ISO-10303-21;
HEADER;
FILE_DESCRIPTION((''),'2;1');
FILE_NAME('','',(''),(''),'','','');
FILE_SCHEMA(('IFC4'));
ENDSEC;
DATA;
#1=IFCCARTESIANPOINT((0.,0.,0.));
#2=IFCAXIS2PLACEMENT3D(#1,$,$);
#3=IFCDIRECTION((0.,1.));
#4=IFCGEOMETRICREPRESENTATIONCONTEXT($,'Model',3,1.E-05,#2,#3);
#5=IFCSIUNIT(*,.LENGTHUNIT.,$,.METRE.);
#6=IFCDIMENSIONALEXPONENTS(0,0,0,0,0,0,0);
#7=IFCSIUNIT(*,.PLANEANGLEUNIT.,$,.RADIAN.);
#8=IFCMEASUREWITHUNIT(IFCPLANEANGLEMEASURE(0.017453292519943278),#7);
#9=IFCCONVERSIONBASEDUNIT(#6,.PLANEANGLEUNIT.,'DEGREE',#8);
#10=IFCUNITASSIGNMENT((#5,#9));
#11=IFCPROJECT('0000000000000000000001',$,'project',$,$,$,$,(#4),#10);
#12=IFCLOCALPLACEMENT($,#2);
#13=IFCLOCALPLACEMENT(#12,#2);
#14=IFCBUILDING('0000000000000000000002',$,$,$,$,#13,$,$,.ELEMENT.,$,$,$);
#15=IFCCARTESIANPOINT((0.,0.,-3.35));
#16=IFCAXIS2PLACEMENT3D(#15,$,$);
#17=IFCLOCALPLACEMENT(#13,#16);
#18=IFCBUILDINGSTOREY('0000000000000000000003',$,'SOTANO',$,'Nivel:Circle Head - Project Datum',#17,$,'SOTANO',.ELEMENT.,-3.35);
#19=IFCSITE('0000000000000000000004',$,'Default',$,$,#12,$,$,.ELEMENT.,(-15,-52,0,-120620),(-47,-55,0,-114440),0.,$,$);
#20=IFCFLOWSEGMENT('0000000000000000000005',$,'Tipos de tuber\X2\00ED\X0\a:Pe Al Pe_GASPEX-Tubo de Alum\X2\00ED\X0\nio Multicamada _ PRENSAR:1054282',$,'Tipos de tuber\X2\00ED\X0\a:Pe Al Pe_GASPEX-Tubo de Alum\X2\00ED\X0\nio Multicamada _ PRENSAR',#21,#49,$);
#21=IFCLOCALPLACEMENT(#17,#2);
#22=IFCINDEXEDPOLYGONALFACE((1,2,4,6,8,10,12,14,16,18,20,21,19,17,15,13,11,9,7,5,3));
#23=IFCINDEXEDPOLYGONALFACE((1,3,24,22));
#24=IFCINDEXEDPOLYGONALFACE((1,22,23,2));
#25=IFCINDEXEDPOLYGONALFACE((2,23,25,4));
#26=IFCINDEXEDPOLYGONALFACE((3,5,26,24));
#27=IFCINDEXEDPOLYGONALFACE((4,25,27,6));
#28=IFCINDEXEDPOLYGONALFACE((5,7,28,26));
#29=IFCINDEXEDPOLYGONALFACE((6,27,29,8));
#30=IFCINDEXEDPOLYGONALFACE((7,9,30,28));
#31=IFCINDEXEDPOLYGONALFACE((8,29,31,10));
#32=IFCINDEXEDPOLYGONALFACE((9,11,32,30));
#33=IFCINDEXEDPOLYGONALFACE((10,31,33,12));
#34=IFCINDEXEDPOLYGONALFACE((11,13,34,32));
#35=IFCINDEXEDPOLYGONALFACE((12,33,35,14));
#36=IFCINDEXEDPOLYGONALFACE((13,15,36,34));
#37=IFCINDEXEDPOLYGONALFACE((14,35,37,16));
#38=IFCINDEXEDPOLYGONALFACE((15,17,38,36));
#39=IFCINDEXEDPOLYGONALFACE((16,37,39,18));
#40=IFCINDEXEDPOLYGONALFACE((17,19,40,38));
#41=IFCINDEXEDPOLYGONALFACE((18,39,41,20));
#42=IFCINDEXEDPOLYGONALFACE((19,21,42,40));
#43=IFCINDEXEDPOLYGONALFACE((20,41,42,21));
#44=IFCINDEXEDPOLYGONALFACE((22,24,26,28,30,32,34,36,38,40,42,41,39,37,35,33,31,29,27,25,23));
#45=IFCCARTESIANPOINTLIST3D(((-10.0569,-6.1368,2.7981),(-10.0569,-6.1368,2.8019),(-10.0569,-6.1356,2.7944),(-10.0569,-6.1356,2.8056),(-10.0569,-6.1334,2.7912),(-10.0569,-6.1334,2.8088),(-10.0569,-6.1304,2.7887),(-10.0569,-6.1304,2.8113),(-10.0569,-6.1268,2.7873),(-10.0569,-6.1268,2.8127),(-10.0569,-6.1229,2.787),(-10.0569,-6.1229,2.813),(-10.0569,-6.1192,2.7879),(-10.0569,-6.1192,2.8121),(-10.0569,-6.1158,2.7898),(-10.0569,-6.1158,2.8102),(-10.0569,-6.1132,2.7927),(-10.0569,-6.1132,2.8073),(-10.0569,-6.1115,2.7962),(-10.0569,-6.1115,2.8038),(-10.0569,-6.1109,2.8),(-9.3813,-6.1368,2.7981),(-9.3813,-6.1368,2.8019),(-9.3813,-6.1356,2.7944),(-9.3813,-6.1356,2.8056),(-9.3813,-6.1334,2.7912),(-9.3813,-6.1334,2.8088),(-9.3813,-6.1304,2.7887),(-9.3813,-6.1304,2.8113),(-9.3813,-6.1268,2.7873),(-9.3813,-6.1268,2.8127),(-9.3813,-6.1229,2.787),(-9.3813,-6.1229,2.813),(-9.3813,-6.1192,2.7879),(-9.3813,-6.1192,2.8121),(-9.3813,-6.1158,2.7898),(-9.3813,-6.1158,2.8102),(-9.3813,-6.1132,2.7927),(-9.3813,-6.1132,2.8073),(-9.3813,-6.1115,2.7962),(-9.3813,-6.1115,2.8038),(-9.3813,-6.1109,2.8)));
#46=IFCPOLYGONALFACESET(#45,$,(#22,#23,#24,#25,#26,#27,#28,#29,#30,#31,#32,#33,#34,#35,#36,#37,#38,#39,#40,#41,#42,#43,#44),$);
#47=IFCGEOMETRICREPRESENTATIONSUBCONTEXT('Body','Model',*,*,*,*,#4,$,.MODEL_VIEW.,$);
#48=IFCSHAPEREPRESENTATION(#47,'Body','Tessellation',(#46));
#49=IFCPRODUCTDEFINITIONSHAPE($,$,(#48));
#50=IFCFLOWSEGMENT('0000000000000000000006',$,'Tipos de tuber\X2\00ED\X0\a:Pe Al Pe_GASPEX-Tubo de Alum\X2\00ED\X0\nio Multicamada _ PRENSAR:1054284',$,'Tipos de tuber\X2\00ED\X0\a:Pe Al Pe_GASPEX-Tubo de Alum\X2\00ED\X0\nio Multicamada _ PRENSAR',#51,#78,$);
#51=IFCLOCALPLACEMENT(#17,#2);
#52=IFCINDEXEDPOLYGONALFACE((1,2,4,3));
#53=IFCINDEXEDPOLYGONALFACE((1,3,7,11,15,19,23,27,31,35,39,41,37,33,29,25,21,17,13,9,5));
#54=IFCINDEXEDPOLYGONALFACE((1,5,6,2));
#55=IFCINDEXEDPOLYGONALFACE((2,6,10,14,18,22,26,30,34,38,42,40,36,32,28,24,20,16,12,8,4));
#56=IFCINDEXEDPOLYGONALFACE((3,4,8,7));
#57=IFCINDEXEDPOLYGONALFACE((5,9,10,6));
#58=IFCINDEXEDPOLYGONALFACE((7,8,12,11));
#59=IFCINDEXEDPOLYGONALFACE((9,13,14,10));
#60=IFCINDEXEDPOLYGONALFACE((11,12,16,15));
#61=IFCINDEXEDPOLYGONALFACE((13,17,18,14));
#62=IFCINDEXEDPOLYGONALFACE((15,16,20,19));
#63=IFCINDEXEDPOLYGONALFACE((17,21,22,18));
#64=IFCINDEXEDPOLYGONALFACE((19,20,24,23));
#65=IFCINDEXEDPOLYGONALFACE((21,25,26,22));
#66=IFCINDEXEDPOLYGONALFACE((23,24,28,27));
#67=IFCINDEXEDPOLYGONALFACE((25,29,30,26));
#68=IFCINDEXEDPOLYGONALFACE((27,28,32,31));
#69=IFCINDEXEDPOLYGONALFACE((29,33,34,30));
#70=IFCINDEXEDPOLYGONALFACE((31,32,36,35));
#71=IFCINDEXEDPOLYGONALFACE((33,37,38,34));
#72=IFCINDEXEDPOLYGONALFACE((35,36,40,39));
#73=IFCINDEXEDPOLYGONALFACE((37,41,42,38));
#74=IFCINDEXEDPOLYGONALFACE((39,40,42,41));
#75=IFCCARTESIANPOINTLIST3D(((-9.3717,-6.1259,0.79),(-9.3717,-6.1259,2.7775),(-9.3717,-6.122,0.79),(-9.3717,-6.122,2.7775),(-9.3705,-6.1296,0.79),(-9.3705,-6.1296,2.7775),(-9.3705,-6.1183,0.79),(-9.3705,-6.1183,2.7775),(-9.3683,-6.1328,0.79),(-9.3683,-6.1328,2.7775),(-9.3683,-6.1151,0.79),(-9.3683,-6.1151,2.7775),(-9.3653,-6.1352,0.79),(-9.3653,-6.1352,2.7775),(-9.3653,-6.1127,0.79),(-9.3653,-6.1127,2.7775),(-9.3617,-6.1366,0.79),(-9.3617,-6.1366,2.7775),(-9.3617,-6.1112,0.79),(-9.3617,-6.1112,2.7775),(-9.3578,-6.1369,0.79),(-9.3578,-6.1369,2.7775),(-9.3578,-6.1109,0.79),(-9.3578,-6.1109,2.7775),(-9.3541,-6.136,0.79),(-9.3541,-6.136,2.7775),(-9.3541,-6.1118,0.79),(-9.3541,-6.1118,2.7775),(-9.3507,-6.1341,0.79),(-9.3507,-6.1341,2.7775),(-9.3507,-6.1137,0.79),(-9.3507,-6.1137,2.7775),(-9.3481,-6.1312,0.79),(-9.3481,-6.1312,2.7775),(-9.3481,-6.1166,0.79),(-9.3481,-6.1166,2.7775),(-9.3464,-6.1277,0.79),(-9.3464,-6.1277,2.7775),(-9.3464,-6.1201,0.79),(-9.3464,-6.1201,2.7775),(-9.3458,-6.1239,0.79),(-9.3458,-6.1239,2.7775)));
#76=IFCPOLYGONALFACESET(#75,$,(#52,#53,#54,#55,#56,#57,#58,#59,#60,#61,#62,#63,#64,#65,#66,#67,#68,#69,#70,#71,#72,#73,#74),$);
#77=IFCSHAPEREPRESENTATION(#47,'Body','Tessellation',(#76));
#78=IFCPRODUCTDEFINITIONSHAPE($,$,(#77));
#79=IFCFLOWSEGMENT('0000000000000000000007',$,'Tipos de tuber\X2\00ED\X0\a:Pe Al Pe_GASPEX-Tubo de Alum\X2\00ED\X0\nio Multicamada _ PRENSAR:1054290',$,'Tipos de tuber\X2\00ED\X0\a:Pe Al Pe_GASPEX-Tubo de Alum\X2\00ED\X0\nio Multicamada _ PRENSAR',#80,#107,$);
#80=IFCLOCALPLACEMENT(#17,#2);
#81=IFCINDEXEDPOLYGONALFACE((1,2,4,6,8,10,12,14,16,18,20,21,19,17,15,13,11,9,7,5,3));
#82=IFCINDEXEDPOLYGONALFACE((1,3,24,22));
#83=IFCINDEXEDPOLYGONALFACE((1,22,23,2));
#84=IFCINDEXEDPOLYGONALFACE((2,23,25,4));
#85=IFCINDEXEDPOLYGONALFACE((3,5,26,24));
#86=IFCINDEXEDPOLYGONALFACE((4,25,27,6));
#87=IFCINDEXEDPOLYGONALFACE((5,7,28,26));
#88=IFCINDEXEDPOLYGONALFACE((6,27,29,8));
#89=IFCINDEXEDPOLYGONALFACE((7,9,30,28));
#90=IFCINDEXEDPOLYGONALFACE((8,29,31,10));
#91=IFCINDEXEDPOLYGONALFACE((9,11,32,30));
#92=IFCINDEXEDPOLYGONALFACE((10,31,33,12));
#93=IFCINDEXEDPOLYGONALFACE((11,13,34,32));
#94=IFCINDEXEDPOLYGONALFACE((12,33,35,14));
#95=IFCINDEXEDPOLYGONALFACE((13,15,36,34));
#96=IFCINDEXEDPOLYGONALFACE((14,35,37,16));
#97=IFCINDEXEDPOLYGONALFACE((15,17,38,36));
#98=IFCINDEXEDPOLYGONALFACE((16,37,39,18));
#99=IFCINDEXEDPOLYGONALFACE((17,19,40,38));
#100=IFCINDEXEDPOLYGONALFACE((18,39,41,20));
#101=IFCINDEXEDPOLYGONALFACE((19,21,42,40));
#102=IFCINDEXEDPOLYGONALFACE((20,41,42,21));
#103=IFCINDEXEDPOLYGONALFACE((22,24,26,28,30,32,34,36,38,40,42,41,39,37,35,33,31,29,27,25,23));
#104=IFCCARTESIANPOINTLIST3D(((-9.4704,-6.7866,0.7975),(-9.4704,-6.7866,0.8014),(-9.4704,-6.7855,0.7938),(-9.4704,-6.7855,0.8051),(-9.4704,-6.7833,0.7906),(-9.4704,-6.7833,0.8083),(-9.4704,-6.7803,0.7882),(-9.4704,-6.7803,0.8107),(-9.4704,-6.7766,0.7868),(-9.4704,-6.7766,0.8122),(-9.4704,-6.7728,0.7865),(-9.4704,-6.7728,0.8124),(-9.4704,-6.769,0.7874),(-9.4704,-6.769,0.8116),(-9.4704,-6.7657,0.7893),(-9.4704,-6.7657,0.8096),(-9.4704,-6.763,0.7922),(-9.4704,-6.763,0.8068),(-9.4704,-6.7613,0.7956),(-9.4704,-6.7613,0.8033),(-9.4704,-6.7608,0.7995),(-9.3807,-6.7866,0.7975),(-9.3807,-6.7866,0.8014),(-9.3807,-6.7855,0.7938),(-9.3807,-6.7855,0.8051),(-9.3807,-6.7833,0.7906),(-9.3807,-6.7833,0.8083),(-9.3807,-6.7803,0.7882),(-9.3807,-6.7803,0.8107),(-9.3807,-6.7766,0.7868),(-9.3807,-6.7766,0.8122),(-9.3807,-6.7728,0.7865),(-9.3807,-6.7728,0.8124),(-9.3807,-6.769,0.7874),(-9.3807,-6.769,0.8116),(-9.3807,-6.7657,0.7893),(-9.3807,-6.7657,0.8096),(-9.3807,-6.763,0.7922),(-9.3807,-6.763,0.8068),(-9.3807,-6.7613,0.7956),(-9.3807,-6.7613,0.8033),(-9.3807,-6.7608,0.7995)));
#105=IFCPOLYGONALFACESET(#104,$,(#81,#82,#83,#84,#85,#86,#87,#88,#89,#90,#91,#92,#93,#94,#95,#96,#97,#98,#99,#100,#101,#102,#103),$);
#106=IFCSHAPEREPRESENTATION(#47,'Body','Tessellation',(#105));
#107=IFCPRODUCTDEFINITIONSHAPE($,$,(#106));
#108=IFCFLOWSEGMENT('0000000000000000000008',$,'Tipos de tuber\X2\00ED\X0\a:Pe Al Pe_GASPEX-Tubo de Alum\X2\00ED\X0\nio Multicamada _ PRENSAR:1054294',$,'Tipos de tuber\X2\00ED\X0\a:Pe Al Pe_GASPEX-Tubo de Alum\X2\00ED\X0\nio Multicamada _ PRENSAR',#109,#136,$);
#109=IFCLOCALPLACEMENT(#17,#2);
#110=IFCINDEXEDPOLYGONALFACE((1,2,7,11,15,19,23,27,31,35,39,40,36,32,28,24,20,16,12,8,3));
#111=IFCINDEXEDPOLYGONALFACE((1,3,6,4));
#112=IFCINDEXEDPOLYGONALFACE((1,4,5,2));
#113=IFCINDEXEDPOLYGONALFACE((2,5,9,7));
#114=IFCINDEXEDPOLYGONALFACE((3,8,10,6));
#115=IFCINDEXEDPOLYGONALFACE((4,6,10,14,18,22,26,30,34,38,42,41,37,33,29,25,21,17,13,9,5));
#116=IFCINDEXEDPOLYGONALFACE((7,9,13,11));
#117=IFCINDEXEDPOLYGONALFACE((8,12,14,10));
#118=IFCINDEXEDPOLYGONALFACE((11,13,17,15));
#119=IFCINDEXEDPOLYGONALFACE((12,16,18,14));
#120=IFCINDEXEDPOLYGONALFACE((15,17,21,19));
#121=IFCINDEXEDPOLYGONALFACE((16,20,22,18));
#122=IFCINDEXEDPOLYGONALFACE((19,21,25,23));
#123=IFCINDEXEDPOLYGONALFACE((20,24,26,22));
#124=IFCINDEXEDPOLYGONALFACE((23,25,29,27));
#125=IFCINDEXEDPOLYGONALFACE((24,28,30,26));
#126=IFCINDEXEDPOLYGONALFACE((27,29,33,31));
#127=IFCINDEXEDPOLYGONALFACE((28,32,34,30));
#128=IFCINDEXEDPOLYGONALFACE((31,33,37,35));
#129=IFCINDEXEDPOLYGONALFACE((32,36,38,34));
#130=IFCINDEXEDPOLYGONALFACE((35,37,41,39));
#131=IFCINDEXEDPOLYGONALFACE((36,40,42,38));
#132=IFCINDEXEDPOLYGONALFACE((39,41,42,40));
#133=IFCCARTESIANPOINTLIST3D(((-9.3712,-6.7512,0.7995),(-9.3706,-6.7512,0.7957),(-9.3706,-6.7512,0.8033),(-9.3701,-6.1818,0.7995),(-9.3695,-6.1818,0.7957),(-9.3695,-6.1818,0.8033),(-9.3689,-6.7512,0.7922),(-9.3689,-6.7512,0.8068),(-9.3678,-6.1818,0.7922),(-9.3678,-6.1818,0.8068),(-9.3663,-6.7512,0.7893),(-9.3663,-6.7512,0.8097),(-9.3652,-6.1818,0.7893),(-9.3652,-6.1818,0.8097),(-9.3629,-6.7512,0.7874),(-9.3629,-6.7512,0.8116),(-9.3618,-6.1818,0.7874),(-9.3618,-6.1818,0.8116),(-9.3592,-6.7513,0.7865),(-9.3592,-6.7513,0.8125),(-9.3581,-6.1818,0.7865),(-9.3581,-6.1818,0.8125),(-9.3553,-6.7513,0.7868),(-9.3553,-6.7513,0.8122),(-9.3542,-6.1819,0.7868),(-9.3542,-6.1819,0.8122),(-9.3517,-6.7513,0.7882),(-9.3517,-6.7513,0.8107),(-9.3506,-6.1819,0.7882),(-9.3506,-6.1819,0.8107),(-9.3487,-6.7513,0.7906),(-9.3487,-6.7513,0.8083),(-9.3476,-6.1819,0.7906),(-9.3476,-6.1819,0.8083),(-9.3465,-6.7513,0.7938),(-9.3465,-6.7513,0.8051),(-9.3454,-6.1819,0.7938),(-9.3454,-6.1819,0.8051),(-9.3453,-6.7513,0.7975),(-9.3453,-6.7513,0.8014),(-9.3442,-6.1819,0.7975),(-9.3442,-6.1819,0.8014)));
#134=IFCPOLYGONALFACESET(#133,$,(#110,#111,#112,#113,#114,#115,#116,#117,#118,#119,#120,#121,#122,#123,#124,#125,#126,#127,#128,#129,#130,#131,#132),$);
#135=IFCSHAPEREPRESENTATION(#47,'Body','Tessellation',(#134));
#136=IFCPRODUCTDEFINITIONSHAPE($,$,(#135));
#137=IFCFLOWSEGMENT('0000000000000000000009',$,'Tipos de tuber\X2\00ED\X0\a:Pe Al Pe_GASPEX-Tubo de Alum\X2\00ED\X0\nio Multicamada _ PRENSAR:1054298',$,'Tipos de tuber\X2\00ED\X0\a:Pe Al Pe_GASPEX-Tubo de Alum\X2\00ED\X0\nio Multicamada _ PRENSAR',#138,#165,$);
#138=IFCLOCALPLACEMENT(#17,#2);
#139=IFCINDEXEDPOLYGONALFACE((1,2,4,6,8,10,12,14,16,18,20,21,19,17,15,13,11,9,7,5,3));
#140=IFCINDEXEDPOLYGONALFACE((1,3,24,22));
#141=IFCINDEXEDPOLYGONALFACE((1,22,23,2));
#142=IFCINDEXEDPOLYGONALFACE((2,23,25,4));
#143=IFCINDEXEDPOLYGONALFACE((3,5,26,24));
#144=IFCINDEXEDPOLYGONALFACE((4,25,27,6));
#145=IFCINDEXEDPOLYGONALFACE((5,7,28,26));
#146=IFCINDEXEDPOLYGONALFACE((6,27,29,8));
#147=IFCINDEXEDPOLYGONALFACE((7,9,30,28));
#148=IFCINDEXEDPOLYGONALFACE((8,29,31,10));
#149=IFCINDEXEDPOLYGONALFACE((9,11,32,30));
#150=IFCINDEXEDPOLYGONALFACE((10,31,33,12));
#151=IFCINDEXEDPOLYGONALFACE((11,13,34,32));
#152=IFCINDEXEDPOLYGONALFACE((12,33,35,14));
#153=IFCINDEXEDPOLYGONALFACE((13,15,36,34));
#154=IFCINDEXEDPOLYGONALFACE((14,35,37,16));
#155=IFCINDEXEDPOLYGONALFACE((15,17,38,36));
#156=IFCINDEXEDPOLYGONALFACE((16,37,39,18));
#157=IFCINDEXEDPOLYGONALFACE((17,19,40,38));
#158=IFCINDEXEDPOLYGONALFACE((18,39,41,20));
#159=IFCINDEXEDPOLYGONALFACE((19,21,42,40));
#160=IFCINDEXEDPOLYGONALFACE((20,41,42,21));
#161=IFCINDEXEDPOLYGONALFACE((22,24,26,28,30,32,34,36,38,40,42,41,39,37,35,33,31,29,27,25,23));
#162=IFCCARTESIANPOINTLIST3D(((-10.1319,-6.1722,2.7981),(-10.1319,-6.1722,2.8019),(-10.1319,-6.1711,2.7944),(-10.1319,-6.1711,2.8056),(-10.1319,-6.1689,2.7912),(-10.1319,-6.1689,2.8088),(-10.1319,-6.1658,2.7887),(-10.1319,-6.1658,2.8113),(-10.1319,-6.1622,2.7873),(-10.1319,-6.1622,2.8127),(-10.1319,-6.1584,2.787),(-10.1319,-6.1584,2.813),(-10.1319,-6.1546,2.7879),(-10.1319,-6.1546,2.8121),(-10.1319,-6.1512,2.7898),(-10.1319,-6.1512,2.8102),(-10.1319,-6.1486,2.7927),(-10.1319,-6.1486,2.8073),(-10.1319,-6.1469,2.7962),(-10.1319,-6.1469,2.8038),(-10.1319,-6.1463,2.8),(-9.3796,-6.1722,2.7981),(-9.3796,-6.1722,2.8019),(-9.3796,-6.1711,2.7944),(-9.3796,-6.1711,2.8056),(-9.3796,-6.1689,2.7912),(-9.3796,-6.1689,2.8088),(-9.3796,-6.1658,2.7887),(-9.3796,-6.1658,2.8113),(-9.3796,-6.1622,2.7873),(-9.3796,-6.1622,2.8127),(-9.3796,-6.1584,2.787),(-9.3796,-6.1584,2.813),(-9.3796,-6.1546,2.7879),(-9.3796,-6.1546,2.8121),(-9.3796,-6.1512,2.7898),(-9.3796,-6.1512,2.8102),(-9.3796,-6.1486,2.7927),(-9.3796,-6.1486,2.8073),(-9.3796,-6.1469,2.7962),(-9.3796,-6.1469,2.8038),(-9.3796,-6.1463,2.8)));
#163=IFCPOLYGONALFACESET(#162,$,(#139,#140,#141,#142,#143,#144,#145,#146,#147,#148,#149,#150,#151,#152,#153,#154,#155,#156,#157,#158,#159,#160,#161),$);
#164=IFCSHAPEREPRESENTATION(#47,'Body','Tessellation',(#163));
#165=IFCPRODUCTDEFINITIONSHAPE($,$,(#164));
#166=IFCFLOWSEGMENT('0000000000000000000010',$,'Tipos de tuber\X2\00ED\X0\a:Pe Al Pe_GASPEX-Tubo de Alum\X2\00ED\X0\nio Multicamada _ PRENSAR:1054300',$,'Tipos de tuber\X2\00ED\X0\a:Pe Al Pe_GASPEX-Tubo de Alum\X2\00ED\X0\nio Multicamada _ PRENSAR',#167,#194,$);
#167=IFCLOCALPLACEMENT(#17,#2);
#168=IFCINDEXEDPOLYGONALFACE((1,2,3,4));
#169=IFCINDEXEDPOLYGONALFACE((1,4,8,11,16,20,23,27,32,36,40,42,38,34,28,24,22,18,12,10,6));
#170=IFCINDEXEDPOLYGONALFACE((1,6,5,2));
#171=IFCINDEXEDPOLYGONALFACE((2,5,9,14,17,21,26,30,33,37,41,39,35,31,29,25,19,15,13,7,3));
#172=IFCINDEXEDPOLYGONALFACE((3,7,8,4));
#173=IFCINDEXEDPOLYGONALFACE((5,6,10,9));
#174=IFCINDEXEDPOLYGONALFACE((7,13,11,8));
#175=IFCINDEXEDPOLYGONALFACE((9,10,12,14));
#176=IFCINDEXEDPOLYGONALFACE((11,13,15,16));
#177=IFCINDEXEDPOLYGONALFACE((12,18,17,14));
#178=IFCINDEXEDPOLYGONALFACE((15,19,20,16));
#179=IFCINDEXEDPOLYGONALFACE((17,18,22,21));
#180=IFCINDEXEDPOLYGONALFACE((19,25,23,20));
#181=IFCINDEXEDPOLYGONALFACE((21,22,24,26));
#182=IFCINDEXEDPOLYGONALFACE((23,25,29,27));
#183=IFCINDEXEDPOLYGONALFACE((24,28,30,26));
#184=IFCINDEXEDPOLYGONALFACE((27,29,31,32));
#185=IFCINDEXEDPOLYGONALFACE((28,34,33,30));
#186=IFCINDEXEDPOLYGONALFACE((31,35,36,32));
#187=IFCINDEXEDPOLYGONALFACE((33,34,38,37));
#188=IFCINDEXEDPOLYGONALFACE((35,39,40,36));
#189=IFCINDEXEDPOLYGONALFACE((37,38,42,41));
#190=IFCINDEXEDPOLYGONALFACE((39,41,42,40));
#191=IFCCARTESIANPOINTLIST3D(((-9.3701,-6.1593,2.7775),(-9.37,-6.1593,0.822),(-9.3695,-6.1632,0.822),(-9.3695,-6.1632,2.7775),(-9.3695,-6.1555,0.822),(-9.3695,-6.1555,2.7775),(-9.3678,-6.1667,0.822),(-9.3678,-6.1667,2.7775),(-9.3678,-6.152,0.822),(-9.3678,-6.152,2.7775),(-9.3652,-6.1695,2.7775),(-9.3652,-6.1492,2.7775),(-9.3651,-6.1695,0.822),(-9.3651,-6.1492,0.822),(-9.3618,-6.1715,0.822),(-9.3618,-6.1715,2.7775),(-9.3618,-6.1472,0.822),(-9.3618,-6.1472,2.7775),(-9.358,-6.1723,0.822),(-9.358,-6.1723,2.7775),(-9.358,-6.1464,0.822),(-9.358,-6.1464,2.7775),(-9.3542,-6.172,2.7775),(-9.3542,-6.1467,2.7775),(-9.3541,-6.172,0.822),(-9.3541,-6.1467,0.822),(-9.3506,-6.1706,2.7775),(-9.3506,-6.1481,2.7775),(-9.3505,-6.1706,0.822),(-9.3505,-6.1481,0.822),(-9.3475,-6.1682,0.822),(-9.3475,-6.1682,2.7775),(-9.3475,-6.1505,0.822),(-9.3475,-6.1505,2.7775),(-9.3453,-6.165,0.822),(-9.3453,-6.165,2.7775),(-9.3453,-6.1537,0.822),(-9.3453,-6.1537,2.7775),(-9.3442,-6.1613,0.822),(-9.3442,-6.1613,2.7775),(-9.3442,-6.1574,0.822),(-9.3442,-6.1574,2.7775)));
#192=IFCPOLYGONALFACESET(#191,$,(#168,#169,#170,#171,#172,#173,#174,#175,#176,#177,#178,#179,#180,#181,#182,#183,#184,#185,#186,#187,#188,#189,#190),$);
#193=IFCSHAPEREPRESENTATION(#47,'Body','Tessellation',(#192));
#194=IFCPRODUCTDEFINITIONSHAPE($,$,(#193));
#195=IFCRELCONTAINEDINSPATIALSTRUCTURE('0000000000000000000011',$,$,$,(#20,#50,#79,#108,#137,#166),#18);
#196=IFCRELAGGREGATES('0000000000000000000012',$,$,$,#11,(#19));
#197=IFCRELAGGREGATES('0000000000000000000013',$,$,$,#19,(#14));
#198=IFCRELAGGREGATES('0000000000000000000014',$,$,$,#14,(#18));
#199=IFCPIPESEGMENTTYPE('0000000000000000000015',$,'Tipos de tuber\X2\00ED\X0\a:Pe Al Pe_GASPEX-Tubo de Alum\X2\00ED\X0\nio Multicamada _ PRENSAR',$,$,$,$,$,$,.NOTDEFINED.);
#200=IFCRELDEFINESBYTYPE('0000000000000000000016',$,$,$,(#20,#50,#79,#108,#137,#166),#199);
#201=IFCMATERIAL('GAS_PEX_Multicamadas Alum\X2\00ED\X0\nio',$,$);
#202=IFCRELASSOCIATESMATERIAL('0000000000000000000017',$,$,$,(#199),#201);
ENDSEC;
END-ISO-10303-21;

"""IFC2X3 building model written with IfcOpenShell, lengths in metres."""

from ifc_helpers import new_model, entity, si_unit, converted_unit, direction, frame, frame_2d, origin, origin_2d_with_axis, place, context, subcontext, project, spatial, circle, extrude, material, type_object, element, save


model = new_model("IFC2X3")

# Units and contexts
model_context = context("Model", 3, precision=1e-05, world=origin(), true_north=direction((0.0, 1.0)))
body_context = subcontext(model_context, "Body", "Model", "MODEL_VIEW")
ifc_project = project(units=[si_unit("LENGTHUNIT", "METRE"), converted_unit("PLANEANGLEUNIT", "DEGREE", entity("IfcPlaneAngleMeasure", 0.017453292519943278), si_unit("PLANEANGLEUNIT", "RADIAN"), dimensions=[0, 0, 0, 0, 0, 0, 0])], contexts=[model_context])

# Site, building, storey
site_placement = place(None, origin())
site = spatial("IfcSite", under=ifc_project, at=site_placement, Name="Default", CompositionType="ELEMENT", RefLatitude=(-15, -52, 0, -120620), RefLongitude=(-47, -55, 0, -114440), RefElevation=0.0)
building_placement = place(site_placement, origin())
building = spatial("IfcBuilding", under=site, at=building_placement, CompositionType="ELEMENT")
storey_placement = place(building_placement, frame((0.0, 0.0, -3.35)))
storey = spatial("IfcBuildingStorey", under=building, at=storey_placement, Name="SOTANO", ObjectType="Nivel:Circle Head - Project Datum", LongName="SOTANO", CompositionType="ELEMENT", Elevation=-3.35)

# Flow segments
ifc_material = material(Name="GAS_PEX_Multicamadas Alumínio")
pipe_segment_type_1 = type_object("IfcPipeSegmentType", Name="Tipos de tubería:Pe Al Pe_GASPEX-Tubo de Alumínio Multicamada _ PRENSAR", PredefinedType="NOTDEFINED", material=ifc_material)
flow_segment_1_placement = place(storey_placement, origin())
element("IfcFlowSegment", 1, at=flow_segment_1_placement, inside=storey, type_object=pipe_segment_type_1, Name="Tipos de tubería:Pe Al Pe_GASPEX-Tubo de Alumínio Multicamada _ PRENSAR:1054282", ObjectType="Tipos de tubería:Pe Al Pe_GASPEX-Tubo de Alumínio Multicamada _ PRENSAR", context=body_context, shape_type="SweptSolid", body=[
    extrude(circle(Radius=0.013, at=origin_2d_with_axis()), frame((-10.0569, -6.1239, 2.8), z_axis=(1.0, 0.0, 0.0), x_axis=(0.0, 1.0, 0.0)), (0.0, 0.0, 1.0), 0.6756),
])
flow_segment_2_placement = place(storey_placement, origin())
element("IfcFlowSegment", 2, at=flow_segment_2_placement, inside=storey, type_object=pipe_segment_type_1, Name="Tipos de tubería:Pe Al Pe_GASPEX-Tubo de Alumínio Multicamada _ PRENSAR:1054284", ObjectType="Tipos de tubería:Pe Al Pe_GASPEX-Tubo de Alumínio Multicamada _ PRENSAR", context=body_context, shape_type="SweptSolid", body=[
    extrude(circle(Radius=0.013, at=origin_2d_with_axis()), frame((-9.3588, -6.1239, 0.79)), (0.0, 0.0, 1.0), 1.9875),
])
flow_segment_3_placement = place(storey_placement, origin())
element("IfcFlowSegment", 3, at=flow_segment_3_placement, inside=storey, type_object=pipe_segment_type_1, Name="Tipos de tubería:Pe Al Pe_GASPEX-Tubo de Alumínio Multicamada _ PRENSAR:1054290", ObjectType="Tipos de tubería:Pe Al Pe_GASPEX-Tubo de Alumínio Multicamada _ PRENSAR", context=body_context, shape_type="SweptSolid", body=[
    extrude(circle(Radius=0.013, at=frame_2d((0.0, 0.0), x_axis=(1.0, 0.0))), frame((-9.4704, -6.7738, 0.7995), z_axis=(1.0, 0.0, 0.0), x_axis=(0.0, 1.0, 0.0)), (0.0, 0.0, 1.0), 0.0897),
])
flow_segment_4_placement = place(storey_placement, origin())
element("IfcFlowSegment", 4, at=flow_segment_4_placement, inside=storey, type_object=pipe_segment_type_1, Name="Tipos de tubería:Pe Al Pe_GASPEX-Tubo de Alumínio Multicamada _ PRENSAR:1054294", ObjectType="Tipos de tubería:Pe Al Pe_GASPEX-Tubo de Alumínio Multicamada _ PRENSAR", context=body_context, shape_type="SweptSolid", body=[
    extrude(circle(Radius=0.013, at=origin_2d_with_axis()), frame((-9.3582, -6.7513, 0.7995), z_axis=(0.001966, 0.999998, 0.0), x_axis=(-0.999998, 0.001966, 0.0)), (0.0, 0.0, 1.0), 0.5694),
])
flow_segment_5_placement = place(storey_placement, origin())
element("IfcFlowSegment", 5, at=flow_segment_5_placement, inside=storey, type_object=pipe_segment_type_1, Name="Tipos de tubería:Pe Al Pe_GASPEX-Tubo de Alumínio Multicamada _ PRENSAR:1054298", ObjectType="Tipos de tubería:Pe Al Pe_GASPEX-Tubo de Alumínio Multicamada _ PRENSAR", context=body_context, shape_type="SweptSolid", body=[
    extrude(circle(Radius=0.013, at=origin_2d_with_axis()), frame((-10.1319, -6.1593, 2.8), z_axis=(1.0, -0.000003, 0.0), x_axis=(0.000003, 1.0, 0.0)), (0.0, 0.0, 1.0), 0.7523),
])
flow_segment_6_placement = place(storey_placement, origin())
element("IfcFlowSegment", 6, at=flow_segment_6_placement, inside=storey, type_object=pipe_segment_type_1, Name="Tipos de tubería:Pe Al Pe_GASPEX-Tubo de Alumínio Multicamada _ PRENSAR:1054300", ObjectType="Tipos de tubería:Pe Al Pe_GASPEX-Tubo de Alumínio Multicamada _ PRENSAR", context=body_context, shape_type="SweptSolid", body=[
    extrude(circle(Radius=0.013, at=origin_2d_with_axis()), frame((-9.357, -6.1593, 0.822), z_axis=(-0.00001, 0.0, 1.0), x_axis=(-1.0, 0.0, -0.00001)), (0.0, 0.0, 1.0), 1.9555),
])

save(model, "model.ifc")
